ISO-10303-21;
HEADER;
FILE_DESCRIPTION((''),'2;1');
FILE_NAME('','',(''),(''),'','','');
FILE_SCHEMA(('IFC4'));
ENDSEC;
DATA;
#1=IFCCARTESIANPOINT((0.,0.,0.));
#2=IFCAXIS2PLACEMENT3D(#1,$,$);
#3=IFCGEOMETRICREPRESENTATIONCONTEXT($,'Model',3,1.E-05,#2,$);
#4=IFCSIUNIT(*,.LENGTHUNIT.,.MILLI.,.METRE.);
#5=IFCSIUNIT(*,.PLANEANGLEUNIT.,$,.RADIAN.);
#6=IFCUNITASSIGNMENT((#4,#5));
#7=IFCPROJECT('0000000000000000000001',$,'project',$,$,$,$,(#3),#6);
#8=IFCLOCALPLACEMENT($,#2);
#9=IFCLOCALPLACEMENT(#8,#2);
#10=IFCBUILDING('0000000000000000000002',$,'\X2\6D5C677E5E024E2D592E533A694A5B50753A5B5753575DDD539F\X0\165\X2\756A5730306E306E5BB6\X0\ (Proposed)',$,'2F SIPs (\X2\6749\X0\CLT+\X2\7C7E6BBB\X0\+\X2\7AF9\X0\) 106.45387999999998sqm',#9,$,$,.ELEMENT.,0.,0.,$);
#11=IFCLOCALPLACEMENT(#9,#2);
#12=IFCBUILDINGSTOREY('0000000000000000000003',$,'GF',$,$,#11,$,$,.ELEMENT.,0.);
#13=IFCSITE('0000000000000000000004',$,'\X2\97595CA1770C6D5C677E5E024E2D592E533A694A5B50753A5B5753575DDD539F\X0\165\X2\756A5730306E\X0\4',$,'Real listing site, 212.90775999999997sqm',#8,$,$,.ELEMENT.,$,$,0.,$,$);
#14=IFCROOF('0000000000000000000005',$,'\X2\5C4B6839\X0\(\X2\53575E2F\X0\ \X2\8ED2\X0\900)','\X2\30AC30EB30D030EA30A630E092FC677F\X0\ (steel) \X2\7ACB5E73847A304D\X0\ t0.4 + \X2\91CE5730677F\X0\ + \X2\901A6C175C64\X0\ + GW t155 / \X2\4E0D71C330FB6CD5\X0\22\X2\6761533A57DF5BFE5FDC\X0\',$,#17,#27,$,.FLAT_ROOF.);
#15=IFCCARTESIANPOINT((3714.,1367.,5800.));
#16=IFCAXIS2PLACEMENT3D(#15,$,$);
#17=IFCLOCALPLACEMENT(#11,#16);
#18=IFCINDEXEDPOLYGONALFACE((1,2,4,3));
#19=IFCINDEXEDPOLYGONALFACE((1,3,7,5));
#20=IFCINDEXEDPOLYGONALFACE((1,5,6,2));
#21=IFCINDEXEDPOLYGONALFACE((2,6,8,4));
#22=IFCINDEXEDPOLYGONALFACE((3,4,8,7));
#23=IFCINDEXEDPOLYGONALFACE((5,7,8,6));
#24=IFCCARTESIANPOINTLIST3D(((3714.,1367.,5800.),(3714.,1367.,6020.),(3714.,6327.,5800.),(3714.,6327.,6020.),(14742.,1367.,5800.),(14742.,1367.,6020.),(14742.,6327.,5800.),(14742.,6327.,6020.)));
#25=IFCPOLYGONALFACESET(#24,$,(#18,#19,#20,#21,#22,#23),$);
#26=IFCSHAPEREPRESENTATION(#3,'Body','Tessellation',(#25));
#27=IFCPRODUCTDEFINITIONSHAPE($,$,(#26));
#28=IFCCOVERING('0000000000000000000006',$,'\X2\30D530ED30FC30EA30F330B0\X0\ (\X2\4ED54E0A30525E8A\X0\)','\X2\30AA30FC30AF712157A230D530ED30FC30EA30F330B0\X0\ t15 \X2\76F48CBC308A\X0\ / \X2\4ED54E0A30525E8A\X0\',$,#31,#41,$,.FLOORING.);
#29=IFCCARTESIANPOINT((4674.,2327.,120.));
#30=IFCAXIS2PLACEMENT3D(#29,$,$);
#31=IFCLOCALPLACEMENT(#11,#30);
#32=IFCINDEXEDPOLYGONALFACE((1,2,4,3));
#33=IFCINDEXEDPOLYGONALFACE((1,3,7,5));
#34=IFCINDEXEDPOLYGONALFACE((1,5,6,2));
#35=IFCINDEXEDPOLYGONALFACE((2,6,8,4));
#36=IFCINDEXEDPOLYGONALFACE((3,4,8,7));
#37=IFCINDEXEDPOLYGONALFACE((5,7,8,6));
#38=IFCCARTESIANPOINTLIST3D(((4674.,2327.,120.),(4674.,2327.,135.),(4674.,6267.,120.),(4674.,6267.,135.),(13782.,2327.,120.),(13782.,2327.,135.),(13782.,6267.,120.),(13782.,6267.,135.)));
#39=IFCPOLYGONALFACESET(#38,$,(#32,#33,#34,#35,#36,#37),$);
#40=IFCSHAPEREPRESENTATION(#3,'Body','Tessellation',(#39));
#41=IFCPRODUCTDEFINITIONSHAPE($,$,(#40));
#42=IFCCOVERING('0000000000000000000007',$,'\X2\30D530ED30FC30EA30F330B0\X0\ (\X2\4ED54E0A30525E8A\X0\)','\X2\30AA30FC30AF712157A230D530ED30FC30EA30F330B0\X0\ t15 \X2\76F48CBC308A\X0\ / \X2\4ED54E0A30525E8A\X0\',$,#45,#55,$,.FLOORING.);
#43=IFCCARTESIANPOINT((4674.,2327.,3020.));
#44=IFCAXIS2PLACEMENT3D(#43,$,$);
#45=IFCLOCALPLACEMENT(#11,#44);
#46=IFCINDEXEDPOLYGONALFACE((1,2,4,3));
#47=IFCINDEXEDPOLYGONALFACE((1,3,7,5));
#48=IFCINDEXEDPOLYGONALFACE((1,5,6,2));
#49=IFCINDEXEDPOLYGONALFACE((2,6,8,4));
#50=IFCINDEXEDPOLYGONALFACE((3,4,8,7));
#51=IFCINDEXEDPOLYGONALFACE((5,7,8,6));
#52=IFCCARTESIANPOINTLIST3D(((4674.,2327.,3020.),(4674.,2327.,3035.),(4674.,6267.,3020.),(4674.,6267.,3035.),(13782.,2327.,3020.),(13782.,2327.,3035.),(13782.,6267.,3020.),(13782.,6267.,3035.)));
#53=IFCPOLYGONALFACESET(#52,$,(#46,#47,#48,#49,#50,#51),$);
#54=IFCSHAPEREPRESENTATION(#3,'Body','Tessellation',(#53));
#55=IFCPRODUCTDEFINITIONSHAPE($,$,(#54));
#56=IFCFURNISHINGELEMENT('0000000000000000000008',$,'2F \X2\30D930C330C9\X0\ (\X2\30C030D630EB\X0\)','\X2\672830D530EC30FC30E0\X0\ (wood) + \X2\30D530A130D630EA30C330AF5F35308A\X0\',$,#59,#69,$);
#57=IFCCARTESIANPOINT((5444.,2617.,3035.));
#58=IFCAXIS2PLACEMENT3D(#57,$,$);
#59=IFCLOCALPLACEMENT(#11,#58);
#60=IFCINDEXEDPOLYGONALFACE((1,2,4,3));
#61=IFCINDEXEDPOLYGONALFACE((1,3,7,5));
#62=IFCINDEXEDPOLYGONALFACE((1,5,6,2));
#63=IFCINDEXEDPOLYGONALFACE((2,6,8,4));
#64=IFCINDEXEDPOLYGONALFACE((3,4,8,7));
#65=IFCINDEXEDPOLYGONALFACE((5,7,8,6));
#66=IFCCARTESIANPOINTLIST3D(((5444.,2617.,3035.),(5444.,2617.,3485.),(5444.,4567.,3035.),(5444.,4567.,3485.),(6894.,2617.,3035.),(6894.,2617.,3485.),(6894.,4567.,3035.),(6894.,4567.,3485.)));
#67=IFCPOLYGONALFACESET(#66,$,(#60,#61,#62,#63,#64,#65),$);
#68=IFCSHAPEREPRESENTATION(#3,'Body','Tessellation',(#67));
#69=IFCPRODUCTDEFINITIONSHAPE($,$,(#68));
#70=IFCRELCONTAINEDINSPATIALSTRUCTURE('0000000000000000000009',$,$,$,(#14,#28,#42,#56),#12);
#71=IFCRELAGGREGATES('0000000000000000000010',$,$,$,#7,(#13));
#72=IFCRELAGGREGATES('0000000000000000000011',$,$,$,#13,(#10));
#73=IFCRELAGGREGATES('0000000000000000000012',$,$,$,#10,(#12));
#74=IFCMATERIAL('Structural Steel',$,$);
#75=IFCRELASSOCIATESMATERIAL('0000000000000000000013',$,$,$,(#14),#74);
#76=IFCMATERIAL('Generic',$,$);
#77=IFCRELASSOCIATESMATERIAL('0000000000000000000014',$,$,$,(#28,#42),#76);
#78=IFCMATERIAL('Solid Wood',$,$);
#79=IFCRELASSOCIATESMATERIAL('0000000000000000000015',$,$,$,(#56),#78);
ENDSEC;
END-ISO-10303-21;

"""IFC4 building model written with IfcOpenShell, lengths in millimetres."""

from ifc_helpers import new_model, si_unit, frame, frame_2d, origin, place, context, project, spatial, rectangle, extrude, material, element, save


model = new_model("IFC4")

# Units and contexts
model_context = context("Model", 3, precision=1e-05, world=origin())
ifc_project = project(units=[si_unit("LENGTHUNIT", "METRE", prefix="MILLI"), si_unit("PLANEANGLEUNIT", "RADIAN")], contexts=[model_context])

# Site, building, storey
site_placement = place(None, origin())
site = spatial("IfcSite", under=ifc_project, at=site_placement, Name="静岡県浜松市中央区楊子町字南川原165番地の4", ObjectType="Real listing site, 212.90775999999997sqm", CompositionType="ELEMENT", RefElevation=0.0)
building_placement = place(site_placement, origin())
building = spatial("IfcBuilding", under=site, at=building_placement, Name="浜松市中央区楊子町字南川原165番地のの家 (Proposed)", ObjectType="2F SIPs (杉CLT+籾殻+竹) 106.45387999999998sqm", CompositionType="ELEMENT", ElevationOfRefHeight=0.0, ElevationOfTerrain=0.0)
storey_placement = place(building_placement, origin())
storey = spatial("IfcBuildingStorey", under=building, at=storey_placement, Name="GF", CompositionType="ELEMENT", Elevation=0.0)

# Shared definitions
ifc_material_1 = material(Name="Solid Wood")

# Roof
ifc_material_2 = material(Name="Structural Steel")
for number, where, name in (
    (1, (3714.0, 1367.0, 5800.0), "屋根(南帯 軒900)"),
):
    element("IfcRoof", number, at=place(storey_placement, frame(where)), inside=storey, material=ifc_material_2, Name=name, Description="ガルバリウム鋼板 (steel) 立平葺き t0.4 + 野地板 + 通気層 + GW t155 / 不燃・法22条区域対応", PredefinedType="FLAT_ROOF", context=model_context, shape_type="SweptSolid", body=[
        extrude(rectangle(XDim=11028.0, YDim=4960.0, at=frame_2d((5514.0, 2480.0))), frame((3714.0, 1367.0, 5800.0)), (0.0, 0.0, 1.0), 220.0),
    ])

# Coverings
ifc_material_3 = material(Name="Generic")
covering_1_placement = place(storey_placement, frame((4674.0, 2327.0, 120.0)))
element("IfcCovering", 2, at=covering_1_placement, inside=storey, material=ifc_material_3, Name="フローリング (仕上げ床)", Description="オーク無垢フローリング t15 直貼り / 仕上げ床", PredefinedType="FLOORING", context=model_context, shape_type="SweptSolid", body=[
    extrude(rectangle(XDim=9108.0, YDim=3940.0, at=frame_2d((4554.0, 1970.0))), frame((4674.0, 2327.0, 120.0)), (0.0, 0.0, 1.0), 15.0),
])
covering_2_placement = place(storey_placement, frame((4674.0, 2327.0, 3020.0)))
element("IfcCovering", 3, at=covering_2_placement, inside=storey, material=ifc_material_3, Name="フローリング (仕上げ床)", Description="オーク無垢フローリング t15 直貼り / 仕上げ床", PredefinedType="FLOORING", context=model_context, shape_type="SweptSolid", body=[
    extrude(rectangle(XDim=9108.0, YDim=3940.0, at=frame_2d((4554.0, 1970.0))), frame((4674.0, 2327.0, 3020.0)), (0.0, 0.0, 1.0), 15.0),
])

# Furnishing element
furnishing_placement = place(storey_placement, frame((5444.0, 2617.0, 3035.0)))
element("IfcFurnishingElement", 4, at=furnishing_placement, inside=storey, material=ifc_material_1, Name="2F ベッド (ダブル)", Description="木フレーム (wood) + ファブリック張り", context=model_context, shape_type="SweptSolid", body=[
    extrude(rectangle(XDim=1450.0, YDim=1950.0, at=frame_2d((725.0, 975.0))), frame((5444.0, 2617.0, 3035.0)), (0.0, 0.0, 1.0), 450.0),
])

save(model, "model.ifc")
